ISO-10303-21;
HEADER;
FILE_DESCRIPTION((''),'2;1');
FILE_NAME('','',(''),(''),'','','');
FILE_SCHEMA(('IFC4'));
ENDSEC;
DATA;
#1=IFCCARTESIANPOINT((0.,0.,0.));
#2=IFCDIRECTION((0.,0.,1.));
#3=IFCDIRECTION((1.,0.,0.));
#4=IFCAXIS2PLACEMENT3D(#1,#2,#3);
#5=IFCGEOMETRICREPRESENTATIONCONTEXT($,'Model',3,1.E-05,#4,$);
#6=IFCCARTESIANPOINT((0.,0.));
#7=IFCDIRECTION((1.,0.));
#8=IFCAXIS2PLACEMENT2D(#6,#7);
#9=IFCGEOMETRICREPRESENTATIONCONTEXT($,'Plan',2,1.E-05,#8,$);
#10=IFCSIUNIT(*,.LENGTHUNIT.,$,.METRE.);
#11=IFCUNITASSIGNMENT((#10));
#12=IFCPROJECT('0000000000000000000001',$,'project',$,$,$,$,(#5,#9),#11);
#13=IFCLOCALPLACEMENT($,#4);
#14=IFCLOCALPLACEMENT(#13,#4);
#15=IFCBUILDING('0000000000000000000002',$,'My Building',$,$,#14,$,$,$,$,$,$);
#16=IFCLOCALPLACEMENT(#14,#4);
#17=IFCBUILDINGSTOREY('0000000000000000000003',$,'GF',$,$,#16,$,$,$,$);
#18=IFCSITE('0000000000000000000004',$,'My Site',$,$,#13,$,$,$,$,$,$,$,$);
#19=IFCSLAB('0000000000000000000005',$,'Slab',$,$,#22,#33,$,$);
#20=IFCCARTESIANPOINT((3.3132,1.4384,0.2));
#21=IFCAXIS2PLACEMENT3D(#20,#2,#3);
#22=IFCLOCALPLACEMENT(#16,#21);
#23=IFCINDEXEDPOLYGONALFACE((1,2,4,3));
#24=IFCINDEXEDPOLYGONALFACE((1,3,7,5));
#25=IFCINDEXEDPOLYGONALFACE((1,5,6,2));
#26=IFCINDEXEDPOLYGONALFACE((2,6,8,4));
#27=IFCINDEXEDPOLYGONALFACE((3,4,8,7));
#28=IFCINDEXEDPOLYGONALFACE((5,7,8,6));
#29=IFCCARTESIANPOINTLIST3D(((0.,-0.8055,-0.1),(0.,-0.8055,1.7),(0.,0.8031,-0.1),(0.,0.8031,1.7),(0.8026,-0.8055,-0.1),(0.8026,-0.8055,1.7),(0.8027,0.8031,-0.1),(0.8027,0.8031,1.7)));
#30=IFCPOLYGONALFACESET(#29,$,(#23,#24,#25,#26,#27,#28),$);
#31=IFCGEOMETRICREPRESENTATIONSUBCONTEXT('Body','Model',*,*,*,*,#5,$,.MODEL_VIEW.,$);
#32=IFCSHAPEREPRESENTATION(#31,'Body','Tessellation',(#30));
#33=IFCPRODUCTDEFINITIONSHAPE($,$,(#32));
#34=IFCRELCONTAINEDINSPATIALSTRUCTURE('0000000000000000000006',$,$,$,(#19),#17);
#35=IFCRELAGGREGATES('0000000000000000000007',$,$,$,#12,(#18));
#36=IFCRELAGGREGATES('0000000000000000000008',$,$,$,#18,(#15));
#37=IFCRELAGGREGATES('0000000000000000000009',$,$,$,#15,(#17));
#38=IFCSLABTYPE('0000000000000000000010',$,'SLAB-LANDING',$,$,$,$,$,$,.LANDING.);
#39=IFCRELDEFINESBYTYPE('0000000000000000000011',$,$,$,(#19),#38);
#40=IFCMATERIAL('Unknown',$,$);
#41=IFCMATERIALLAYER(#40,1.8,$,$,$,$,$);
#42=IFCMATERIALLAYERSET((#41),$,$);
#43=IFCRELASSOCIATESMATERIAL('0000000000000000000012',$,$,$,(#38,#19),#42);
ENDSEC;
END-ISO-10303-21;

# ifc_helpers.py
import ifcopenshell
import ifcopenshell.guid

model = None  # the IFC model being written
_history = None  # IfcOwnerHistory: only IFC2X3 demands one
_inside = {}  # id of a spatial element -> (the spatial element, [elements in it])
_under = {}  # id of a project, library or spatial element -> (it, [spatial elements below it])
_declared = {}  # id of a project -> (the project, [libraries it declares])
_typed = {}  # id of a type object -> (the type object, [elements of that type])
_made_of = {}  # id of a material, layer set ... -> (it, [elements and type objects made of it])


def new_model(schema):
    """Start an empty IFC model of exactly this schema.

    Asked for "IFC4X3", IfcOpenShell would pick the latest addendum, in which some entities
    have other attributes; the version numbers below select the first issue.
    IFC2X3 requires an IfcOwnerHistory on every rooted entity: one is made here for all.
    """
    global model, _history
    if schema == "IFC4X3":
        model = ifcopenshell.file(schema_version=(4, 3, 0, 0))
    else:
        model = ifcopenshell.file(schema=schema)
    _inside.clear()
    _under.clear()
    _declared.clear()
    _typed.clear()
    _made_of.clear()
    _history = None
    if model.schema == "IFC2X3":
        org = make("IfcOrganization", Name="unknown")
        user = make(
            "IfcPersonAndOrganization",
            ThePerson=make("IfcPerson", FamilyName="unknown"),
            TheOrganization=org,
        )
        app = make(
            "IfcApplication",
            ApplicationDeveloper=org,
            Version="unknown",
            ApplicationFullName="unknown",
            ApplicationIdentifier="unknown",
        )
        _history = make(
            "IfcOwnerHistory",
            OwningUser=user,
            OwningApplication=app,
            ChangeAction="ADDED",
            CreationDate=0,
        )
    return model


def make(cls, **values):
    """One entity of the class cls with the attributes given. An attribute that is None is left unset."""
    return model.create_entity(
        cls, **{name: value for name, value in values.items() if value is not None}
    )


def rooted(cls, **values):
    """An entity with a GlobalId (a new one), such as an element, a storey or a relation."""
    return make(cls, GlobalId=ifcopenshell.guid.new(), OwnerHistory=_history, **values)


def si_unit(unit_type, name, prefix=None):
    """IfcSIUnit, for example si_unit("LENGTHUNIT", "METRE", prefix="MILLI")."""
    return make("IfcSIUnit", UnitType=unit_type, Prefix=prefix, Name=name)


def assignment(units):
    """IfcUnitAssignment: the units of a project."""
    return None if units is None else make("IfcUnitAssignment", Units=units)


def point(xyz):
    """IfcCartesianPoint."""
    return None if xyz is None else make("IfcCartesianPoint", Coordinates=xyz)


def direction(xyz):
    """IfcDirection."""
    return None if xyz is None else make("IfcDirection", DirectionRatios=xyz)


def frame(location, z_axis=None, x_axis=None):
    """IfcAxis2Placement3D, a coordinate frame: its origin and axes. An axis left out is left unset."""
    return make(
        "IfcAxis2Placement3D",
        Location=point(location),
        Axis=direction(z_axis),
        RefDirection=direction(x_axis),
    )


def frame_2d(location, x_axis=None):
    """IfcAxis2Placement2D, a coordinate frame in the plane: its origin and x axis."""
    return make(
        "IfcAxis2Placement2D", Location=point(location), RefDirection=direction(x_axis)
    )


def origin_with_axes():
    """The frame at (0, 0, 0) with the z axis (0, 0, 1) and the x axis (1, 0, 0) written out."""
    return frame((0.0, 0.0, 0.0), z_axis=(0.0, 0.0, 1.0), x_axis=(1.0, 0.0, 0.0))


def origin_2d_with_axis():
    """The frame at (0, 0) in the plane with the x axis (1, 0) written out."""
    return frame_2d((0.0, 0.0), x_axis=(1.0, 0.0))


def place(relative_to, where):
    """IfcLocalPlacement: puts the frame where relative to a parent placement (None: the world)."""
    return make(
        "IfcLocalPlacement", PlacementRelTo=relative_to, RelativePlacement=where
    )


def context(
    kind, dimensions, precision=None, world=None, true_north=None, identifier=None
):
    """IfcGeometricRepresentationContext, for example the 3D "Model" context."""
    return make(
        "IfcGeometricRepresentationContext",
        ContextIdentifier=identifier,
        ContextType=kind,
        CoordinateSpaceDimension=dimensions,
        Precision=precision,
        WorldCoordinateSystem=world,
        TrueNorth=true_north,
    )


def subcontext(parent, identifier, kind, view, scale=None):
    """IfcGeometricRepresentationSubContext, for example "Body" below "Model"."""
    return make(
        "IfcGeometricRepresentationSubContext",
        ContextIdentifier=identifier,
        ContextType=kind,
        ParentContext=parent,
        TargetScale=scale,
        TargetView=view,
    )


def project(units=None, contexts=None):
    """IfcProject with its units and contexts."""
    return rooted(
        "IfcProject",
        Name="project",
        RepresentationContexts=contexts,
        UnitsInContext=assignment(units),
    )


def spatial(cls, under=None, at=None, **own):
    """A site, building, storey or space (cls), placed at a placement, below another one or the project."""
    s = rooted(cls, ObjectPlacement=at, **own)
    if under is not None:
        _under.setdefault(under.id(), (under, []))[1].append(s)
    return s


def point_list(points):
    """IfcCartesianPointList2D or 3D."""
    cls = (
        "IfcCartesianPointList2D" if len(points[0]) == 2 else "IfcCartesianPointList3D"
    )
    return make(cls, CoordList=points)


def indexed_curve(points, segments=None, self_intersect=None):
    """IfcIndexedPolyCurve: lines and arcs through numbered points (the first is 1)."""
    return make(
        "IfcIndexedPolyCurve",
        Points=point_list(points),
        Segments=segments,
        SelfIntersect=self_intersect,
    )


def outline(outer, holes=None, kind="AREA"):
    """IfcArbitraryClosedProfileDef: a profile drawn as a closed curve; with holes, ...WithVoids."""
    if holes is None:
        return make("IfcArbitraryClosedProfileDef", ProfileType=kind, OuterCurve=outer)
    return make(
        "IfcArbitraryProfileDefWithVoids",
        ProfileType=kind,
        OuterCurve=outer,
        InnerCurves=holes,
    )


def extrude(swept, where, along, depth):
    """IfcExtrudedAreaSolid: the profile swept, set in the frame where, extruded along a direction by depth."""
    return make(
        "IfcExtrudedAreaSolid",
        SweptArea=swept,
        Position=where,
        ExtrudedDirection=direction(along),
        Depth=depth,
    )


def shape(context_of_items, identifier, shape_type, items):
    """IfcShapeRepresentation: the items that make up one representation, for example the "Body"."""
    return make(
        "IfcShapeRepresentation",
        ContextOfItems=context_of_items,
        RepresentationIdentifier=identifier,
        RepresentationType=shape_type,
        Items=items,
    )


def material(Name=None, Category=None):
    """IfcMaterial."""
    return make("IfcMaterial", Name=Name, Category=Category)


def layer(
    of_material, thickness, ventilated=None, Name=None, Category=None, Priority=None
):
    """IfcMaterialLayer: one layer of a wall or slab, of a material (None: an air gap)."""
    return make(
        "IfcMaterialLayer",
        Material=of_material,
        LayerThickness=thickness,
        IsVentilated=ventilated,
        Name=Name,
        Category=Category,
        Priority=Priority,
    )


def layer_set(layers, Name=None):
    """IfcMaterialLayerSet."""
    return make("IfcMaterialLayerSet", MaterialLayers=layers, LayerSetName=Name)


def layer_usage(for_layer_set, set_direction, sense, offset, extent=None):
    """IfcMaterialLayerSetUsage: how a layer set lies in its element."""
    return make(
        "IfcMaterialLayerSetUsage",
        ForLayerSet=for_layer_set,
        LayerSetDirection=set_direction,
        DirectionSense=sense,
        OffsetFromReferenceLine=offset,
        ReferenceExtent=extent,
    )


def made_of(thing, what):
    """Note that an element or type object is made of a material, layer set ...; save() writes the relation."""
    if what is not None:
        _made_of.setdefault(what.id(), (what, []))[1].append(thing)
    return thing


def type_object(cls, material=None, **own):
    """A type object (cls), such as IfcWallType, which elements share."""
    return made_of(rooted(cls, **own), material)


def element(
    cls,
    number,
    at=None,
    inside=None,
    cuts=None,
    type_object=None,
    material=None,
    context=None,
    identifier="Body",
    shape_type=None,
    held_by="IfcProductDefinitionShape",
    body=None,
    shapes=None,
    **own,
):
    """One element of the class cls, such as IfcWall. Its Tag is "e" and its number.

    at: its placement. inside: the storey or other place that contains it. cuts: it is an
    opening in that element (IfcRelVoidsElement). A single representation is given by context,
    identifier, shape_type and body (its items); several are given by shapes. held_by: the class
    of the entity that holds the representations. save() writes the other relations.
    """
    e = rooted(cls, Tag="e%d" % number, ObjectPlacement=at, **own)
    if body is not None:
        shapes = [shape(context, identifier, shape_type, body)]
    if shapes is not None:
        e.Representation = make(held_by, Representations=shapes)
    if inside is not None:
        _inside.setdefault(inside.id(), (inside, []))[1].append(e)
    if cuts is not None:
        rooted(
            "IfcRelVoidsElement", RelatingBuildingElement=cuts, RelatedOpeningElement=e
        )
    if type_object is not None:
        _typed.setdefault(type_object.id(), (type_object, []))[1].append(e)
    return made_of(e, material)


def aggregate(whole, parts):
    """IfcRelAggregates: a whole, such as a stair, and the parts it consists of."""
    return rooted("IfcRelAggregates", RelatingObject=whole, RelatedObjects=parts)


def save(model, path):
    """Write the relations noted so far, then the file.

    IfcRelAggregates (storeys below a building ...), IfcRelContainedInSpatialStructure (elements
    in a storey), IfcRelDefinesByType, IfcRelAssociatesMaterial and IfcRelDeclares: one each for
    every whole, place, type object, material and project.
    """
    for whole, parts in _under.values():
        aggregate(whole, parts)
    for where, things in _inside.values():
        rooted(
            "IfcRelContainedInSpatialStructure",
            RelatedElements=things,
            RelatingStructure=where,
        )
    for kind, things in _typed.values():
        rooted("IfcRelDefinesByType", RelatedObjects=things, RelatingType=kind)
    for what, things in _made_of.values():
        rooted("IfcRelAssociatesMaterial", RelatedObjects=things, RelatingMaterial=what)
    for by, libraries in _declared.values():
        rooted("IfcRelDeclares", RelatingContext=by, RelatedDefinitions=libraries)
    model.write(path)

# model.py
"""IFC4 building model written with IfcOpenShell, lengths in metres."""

from ifc_helpers import new_model, si_unit, frame, origin_with_axes, origin_2d_with_axis, place, context, subcontext, project, spatial, indexed_curve, outline, extrude, material, layer, layer_set, layer_usage, type_object, element, save


model = new_model("IFC4")

# Units and contexts
model_context = context("Model", 3, precision=1e-05, world=origin_with_axes())
plan_context = context("Plan", 2, precision=1e-05, world=origin_2d_with_axis())
body_context_1 = subcontext(model_context, "Body", "Model", "MODEL_VIEW")
ifc_project = project(units=[si_unit("LENGTHUNIT", "METRE")], contexts=[model_context, plan_context])

# Site, building, storey
site_placement = place(None, origin_with_axes())
site = spatial("IfcSite", under=ifc_project, at=site_placement, Name="My Site")
building_placement = place(site_placement, origin_with_axes())
building = spatial("IfcBuilding", under=site, at=building_placement, Name="My Building")
storey_placement = place(building_placement, origin_with_axes())
storey = spatial("IfcBuildingStorey", under=building, at=storey_placement, Name="GF")

# Shared definitions
ifc_material = material(Name="Unknown")

# Slab
ifc_layer_1 = layer(ifc_material, 1.8)
ifc_layer_set_1 = layer_set([ifc_layer_1])
ifc_layer_usage_1 = layer_usage(ifc_layer_set_1, "AXIS3", "POSITIVE", -0.1)
slab_type_1 = type_object("IfcSlabType", Name="SLAB-LANDING", PredefinedType="LANDING", material=ifc_layer_set_1)
slab_1_placement = place(storey_placement, frame((3.3132, 1.4384, 0.2), z_axis=(0.0, 0.0, 1.0), x_axis=(1.0, 0.0, 0.0)))
element("IfcSlab", 1, at=slab_1_placement, inside=storey, type_object=slab_type_1, material=ifc_layer_usage_1, Name="Slab", context=body_context_1, shape_type="SweptSolid", body=[
    extrude(outline(indexed_curve([(0.8027, 0.8031), (0.8026, -0.8055), (0.0, -0.8055), (0.0, 0.8031), (0.8027, 0.8031)])), frame((0.0, 0.0, -0.1), z_axis=(0.0, 0.0, 1.0), x_axis=(1.0, 0.0, 0.0)), (0.0, 0.0, 1.0), 1.8),
])

save(model, "model.ifc")
